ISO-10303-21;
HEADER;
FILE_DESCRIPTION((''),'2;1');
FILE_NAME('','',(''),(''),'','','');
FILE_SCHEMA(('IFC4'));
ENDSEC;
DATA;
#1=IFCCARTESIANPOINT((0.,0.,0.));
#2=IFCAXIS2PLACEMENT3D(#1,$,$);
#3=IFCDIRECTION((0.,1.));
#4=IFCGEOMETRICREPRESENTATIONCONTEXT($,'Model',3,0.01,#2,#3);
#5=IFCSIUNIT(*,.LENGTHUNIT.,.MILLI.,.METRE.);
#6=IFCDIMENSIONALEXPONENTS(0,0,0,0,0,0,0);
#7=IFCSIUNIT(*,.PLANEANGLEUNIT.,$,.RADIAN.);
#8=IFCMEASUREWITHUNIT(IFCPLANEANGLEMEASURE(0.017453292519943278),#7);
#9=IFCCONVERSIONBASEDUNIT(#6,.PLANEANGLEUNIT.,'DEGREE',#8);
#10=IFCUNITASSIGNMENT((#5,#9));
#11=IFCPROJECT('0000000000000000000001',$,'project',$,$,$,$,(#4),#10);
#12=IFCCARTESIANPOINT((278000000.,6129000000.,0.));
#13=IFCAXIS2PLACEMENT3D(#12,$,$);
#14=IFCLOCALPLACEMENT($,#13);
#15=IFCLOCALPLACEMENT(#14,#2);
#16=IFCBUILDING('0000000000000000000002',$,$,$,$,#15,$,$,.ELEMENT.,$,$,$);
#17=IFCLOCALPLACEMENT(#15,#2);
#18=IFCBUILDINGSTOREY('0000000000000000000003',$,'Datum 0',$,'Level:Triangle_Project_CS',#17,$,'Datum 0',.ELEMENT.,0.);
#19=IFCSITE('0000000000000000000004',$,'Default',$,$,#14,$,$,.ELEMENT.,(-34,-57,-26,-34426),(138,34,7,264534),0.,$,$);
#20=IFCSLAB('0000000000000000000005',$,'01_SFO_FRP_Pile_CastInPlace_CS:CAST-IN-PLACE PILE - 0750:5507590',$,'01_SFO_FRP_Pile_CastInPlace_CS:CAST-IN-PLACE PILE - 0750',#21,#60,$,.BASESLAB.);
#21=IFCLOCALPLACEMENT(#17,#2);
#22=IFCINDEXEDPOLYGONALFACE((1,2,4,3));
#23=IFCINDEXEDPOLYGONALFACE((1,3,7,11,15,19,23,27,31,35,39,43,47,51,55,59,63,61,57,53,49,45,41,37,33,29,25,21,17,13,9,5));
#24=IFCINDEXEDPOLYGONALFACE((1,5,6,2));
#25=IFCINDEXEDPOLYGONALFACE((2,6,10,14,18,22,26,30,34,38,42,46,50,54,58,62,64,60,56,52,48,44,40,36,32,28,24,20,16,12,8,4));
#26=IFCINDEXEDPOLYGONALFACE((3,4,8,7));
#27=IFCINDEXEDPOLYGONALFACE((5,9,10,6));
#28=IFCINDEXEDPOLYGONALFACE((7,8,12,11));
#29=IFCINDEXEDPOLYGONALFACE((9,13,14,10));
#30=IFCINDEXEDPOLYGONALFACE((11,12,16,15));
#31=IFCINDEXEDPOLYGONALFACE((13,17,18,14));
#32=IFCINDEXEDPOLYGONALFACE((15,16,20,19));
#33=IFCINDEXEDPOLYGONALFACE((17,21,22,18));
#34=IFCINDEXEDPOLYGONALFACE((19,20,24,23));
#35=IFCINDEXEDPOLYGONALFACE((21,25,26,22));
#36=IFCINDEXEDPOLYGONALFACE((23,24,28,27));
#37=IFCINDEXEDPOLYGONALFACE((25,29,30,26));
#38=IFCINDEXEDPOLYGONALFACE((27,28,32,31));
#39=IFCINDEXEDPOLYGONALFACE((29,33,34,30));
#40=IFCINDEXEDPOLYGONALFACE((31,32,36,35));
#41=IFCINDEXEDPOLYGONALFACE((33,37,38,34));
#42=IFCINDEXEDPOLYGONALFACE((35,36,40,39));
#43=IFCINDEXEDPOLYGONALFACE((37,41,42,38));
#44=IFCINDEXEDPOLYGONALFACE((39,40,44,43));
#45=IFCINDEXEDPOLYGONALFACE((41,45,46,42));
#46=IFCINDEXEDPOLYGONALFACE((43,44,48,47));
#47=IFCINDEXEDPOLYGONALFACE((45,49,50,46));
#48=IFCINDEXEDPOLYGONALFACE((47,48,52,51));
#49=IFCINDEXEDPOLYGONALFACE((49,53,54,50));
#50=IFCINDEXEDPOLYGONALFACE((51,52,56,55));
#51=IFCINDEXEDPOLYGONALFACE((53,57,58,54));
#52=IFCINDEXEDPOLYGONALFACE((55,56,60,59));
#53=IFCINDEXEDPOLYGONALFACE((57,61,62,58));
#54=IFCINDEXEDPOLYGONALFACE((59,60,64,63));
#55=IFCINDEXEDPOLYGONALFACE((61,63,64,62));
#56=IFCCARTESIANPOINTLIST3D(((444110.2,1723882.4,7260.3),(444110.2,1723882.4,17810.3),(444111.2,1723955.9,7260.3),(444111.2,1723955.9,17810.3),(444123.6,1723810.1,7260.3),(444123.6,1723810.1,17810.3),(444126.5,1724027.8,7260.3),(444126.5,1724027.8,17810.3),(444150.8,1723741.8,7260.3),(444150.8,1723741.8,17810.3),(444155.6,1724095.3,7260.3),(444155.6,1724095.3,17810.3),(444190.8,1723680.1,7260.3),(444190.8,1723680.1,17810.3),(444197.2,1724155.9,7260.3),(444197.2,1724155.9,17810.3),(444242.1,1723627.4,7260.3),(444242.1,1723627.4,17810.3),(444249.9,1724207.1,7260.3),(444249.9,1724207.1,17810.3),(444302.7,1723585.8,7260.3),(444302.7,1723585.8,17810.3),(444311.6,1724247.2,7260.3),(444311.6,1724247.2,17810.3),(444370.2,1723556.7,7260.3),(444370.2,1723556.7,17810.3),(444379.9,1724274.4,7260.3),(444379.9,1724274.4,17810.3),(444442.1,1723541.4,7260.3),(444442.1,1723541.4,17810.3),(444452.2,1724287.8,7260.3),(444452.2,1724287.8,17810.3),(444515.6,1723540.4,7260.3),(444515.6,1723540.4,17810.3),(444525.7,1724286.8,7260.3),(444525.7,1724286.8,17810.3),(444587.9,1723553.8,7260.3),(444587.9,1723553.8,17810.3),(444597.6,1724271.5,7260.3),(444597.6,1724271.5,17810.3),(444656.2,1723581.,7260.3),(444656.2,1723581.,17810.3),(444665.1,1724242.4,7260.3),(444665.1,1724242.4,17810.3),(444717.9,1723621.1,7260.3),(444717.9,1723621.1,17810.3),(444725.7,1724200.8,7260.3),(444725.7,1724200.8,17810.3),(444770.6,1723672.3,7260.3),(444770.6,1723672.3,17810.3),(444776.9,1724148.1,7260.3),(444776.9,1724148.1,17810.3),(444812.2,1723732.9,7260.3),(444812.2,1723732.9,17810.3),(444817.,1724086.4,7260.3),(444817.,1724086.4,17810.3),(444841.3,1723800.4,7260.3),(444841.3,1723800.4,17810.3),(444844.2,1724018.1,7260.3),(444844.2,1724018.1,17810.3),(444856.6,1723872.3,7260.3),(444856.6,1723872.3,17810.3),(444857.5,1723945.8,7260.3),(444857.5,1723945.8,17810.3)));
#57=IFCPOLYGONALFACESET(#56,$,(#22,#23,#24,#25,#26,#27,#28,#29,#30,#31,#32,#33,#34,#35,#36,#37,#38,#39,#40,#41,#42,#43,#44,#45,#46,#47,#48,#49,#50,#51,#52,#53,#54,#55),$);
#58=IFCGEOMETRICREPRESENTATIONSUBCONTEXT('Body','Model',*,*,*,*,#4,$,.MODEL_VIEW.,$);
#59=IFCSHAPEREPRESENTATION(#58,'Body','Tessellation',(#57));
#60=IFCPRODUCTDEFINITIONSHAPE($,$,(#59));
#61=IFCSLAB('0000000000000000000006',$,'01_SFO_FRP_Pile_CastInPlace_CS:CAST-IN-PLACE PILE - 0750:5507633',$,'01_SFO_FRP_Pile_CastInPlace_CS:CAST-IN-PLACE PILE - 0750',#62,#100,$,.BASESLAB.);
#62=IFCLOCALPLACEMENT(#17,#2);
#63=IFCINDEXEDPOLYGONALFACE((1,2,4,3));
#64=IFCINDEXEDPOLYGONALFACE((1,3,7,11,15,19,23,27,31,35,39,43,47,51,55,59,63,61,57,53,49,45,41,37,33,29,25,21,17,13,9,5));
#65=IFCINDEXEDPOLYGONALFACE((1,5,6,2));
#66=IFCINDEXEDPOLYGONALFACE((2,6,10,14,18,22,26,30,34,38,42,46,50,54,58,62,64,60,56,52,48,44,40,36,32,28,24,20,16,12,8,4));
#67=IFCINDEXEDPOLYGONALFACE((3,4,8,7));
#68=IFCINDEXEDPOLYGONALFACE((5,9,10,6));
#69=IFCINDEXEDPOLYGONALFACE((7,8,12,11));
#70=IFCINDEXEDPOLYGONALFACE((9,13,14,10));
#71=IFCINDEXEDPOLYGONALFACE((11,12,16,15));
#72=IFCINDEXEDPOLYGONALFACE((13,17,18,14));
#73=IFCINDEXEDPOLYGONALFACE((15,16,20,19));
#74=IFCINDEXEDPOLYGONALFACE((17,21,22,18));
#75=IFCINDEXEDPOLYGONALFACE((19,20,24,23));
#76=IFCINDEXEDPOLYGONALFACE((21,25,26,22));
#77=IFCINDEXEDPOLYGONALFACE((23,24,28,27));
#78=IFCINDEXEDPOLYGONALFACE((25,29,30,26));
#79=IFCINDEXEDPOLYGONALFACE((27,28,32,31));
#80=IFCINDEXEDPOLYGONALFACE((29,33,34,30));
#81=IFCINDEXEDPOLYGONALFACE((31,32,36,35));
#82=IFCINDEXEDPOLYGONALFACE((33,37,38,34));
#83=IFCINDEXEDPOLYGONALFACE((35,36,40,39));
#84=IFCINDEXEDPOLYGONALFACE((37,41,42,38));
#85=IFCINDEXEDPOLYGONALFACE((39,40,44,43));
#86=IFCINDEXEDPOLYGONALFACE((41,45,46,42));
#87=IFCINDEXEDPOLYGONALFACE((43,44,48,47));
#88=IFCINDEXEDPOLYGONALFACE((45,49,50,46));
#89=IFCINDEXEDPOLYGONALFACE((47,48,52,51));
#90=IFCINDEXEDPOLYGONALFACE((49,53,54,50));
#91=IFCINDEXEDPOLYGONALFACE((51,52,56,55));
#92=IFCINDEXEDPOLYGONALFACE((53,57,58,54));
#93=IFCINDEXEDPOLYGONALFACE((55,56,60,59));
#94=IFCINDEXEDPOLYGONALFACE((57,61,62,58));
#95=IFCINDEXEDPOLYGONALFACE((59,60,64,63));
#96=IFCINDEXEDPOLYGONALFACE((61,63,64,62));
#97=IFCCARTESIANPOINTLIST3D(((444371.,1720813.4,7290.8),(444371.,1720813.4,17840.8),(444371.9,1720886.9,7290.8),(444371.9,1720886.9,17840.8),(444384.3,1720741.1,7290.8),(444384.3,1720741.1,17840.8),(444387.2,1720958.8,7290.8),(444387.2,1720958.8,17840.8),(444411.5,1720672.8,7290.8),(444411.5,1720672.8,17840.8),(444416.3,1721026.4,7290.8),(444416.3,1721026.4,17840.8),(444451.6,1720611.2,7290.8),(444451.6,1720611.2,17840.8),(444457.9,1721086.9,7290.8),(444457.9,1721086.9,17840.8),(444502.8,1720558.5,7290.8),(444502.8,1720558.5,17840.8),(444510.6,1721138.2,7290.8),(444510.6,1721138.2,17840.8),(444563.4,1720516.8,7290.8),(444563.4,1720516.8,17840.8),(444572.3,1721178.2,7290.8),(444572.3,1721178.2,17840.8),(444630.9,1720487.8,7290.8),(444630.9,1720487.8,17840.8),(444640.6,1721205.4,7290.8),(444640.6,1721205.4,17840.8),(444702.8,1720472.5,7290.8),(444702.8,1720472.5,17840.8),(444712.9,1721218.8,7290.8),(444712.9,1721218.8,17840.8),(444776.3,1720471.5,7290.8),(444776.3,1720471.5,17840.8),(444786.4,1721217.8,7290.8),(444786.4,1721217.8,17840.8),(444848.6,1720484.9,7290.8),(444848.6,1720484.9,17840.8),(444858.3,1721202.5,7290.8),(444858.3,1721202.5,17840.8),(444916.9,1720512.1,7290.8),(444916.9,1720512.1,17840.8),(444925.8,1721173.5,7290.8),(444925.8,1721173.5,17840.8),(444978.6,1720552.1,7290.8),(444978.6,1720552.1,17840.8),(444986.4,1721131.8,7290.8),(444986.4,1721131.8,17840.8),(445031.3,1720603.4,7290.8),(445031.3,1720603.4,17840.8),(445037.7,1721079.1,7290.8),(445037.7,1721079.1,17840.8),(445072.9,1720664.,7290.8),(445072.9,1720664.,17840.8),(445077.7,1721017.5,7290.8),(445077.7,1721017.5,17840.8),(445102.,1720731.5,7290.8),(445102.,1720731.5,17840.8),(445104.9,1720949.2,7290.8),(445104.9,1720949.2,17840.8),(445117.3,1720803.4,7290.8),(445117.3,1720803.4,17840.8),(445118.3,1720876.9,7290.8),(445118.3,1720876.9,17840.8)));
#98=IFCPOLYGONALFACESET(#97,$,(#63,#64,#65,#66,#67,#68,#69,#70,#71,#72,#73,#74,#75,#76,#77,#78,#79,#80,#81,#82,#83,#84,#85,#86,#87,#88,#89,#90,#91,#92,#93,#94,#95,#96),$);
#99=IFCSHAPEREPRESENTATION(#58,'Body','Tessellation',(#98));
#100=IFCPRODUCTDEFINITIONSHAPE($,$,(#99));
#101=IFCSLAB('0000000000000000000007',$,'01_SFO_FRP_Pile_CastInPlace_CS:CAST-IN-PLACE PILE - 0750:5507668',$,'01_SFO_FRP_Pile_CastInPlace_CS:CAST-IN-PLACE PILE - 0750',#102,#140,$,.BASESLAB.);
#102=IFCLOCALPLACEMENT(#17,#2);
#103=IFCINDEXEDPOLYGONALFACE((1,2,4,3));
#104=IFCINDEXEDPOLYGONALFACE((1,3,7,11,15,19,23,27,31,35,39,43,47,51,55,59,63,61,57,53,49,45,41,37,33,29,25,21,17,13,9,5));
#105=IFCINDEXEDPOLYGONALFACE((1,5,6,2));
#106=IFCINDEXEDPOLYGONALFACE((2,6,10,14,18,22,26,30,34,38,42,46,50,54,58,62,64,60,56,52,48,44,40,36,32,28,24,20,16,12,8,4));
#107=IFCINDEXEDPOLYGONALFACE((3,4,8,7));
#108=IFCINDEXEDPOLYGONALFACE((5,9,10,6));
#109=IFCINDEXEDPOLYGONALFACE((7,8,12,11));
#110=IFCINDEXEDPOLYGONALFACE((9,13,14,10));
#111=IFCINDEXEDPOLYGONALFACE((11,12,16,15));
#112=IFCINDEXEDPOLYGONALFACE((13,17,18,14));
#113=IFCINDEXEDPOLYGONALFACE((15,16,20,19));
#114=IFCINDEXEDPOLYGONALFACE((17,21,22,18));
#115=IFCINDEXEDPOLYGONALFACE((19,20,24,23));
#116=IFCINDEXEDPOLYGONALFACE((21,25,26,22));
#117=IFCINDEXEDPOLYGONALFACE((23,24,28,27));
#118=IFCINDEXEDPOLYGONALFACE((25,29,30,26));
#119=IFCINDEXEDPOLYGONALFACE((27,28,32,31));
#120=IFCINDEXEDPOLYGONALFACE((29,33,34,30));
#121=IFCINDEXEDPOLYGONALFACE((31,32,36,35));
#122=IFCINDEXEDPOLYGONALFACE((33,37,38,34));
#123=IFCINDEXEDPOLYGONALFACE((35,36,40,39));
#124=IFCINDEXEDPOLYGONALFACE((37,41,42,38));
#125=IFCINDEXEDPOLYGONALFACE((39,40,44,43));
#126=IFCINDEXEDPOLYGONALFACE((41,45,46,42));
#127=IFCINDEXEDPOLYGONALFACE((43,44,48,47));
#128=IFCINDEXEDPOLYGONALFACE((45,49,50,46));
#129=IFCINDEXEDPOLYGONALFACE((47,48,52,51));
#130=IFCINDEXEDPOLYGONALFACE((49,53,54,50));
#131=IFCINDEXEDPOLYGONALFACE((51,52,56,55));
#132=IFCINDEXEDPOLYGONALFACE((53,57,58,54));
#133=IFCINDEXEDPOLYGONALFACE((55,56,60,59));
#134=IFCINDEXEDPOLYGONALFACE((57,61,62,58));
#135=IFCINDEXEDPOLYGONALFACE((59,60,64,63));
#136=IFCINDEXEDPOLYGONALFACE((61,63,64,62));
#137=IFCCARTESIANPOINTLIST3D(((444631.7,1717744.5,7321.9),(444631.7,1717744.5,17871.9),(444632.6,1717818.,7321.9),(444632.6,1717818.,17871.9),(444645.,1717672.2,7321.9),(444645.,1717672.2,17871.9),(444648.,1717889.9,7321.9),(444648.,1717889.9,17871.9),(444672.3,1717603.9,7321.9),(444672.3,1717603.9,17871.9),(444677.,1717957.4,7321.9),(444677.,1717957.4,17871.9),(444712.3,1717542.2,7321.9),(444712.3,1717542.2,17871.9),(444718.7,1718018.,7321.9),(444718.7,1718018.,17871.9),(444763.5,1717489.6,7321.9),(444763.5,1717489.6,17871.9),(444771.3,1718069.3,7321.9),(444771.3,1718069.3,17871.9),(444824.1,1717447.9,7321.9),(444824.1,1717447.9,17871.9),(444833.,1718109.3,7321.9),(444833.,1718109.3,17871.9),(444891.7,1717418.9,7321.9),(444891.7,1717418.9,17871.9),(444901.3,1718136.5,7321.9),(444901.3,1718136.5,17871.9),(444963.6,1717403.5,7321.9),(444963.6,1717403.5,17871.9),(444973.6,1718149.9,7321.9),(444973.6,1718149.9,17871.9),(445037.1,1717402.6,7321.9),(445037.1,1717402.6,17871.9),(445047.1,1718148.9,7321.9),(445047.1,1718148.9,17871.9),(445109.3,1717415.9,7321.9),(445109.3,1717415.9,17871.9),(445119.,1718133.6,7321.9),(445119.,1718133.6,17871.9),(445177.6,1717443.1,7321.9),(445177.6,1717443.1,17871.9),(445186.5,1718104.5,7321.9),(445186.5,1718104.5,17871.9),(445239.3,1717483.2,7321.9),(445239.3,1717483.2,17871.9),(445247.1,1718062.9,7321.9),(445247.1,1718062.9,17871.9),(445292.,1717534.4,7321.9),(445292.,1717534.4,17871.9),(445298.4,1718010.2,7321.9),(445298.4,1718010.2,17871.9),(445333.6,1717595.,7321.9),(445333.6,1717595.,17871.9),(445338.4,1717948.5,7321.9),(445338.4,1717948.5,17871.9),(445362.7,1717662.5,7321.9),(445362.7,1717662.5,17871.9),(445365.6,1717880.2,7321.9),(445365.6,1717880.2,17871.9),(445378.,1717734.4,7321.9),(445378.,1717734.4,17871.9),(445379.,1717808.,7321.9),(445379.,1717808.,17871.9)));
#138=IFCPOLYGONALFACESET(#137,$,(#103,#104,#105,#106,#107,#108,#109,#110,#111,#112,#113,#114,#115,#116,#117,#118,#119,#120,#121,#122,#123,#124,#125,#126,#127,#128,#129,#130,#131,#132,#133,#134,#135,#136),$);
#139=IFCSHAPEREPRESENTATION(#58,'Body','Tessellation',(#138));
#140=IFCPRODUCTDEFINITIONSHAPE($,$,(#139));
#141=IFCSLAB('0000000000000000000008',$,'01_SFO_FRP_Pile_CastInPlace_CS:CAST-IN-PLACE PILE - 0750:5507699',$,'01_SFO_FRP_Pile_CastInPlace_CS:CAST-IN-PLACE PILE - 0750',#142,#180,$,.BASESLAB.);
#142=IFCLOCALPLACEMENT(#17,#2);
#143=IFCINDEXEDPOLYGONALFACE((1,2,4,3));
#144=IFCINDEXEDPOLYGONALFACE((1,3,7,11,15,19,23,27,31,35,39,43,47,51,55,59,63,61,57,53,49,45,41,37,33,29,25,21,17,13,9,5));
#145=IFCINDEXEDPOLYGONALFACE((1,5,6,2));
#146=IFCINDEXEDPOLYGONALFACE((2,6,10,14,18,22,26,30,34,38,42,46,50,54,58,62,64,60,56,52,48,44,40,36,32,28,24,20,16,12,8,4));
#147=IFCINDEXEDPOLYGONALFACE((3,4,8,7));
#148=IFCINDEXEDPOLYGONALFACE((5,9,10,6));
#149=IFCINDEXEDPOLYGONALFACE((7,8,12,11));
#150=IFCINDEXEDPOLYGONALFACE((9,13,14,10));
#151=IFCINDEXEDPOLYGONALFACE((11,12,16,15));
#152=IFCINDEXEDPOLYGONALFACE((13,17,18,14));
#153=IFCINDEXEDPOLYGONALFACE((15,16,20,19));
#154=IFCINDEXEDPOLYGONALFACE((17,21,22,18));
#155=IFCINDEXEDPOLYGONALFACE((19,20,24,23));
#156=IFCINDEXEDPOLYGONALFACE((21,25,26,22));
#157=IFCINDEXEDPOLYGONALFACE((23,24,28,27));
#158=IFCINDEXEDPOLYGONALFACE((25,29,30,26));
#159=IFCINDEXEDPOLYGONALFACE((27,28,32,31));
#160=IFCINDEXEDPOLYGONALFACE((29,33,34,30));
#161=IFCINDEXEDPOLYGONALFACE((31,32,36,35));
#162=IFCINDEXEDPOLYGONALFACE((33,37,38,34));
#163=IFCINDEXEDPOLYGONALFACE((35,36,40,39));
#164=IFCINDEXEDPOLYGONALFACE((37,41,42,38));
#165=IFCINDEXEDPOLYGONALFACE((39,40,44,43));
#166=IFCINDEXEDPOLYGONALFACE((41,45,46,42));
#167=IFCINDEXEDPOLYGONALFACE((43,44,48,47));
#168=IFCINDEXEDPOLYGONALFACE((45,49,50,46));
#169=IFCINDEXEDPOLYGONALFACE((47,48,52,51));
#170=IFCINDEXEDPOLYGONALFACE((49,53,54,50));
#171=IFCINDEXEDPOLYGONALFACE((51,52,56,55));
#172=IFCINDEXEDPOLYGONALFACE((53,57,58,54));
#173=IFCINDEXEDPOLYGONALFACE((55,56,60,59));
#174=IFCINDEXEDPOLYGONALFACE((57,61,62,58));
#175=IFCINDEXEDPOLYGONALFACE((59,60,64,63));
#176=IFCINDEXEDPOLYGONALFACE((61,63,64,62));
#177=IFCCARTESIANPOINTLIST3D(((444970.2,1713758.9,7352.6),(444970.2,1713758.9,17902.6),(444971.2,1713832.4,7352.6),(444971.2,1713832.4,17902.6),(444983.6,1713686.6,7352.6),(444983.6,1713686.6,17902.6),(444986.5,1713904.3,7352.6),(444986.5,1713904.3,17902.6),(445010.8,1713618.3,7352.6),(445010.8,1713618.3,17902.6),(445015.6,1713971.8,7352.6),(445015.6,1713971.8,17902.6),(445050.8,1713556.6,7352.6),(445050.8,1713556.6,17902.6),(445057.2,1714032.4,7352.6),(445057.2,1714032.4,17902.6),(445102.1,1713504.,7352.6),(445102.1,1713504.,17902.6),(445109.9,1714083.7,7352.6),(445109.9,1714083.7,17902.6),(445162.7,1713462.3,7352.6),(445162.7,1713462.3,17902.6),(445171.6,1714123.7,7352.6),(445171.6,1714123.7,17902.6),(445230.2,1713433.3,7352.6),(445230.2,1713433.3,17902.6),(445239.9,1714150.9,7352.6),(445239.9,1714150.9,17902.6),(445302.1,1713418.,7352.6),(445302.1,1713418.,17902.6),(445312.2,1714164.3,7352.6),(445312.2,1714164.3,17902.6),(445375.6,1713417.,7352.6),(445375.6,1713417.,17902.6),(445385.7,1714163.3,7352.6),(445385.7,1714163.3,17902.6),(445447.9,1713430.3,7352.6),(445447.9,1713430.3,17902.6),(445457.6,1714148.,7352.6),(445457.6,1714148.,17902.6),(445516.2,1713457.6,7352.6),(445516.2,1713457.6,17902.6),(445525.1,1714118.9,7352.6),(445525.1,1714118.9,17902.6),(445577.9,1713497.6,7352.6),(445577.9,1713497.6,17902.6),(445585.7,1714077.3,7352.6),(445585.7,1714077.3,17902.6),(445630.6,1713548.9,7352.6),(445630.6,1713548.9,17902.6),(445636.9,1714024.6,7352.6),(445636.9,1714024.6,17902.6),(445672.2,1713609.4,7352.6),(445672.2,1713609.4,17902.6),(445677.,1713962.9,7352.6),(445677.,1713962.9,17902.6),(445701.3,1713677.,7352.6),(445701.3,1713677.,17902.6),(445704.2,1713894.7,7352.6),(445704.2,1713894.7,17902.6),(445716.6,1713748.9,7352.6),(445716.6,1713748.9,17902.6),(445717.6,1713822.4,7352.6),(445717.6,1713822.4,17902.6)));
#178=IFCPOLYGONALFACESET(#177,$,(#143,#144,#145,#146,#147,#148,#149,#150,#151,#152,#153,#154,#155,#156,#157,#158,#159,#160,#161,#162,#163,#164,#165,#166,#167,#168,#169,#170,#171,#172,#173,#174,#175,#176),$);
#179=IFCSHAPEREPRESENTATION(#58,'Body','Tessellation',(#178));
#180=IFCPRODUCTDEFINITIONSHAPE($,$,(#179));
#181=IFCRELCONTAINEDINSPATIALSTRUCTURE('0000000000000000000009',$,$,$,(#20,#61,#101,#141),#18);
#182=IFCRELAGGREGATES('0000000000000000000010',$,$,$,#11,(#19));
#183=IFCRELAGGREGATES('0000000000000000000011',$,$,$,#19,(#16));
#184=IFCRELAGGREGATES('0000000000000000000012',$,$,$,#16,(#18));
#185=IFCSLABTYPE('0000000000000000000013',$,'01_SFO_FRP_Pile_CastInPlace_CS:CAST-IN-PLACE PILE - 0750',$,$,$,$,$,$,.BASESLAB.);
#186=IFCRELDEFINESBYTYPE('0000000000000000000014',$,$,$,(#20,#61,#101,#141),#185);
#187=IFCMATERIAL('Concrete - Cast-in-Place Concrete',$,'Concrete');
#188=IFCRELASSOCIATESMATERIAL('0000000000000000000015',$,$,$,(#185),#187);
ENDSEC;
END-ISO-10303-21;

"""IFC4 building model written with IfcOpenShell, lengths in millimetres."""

from ifc_helpers import new_model, entity, si_unit, converted_unit, direction, frame, origin, place, context, subcontext, project, spatial, arc, indexed_curve, outline, extrude, material, type_object, element, save


model = new_model("IFC4")

# Units and contexts
model_context = context("Model", 3, precision=0.01, world=origin(), true_north=direction((0.0, 1.0)))
body_context = subcontext(model_context, "Body", "Model", "MODEL_VIEW")
ifc_project = project(units=[si_unit("LENGTHUNIT", "METRE", prefix="MILLI"), converted_unit("PLANEANGLEUNIT", "DEGREE", entity("IfcPlaneAngleMeasure", 0.017453292519943278), si_unit("PLANEANGLEUNIT", "RADIAN"), dimensions=[0, 0, 0, 0, 0, 0, 0])], contexts=[model_context])

# Site, building, storey
site_placement = place(None, frame((278000000.0, 6129000000.0, 0.0)))
site = spatial("IfcSite", under=ifc_project, at=site_placement, Name="Default", CompositionType="ELEMENT", RefLatitude=(-34, -57, -26, -34426), RefLongitude=(138, 34, 7, 264534), RefElevation=0.0)
building_placement = place(site_placement, origin())
building = spatial("IfcBuilding", under=site, at=building_placement, CompositionType="ELEMENT")
storey_placement = place(building_placement, frame((0.0, 0.0, 0.0)))
storey = spatial("IfcBuildingStorey", under=building, at=storey_placement, Name="Datum 0", ObjectType="Level:Triangle_Project_CS", LongName="Datum 0", CompositionType="ELEMENT", Elevation=0.0)

# Shared definitions
ifc_material_1 = material(Name="Concrete - Cast-in-Place Concrete", Category="Concrete")

# Slabs
slab_type_1 = type_object("IfcSlabType", Name="01_SFO_FRP_Pile_CastInPlace_CS:CAST-IN-PLACE PILE - 0750", PredefinedType="BASESLAB", material=ifc_material_1)
slab_1_placement = place(storey_placement, origin())
element("IfcSlab", 1, at=slab_1_placement, inside=storey, type_object=slab_type_1, Name="01_SFO_FRP_Pile_CastInPlace_CS:CAST-IN-PLACE PILE - 0750:5507590", ObjectType="01_SFO_FRP_Pile_CastInPlace_CS:CAST-IN-PLACE PILE - 0750", PredefinedType="BASESLAB", context=body_context, shape_type="SweptSolid", body=[
    extrude(outline(indexed_curve([(-375.0, 0.0), (0.0, -375.0), (375.0, 0.0), (0.0, 375.0)], segments=[arc(1, 2, 3), arc(3, 4, 1)], self_intersect=False)), frame((444483.9, 1723914.1, 7260.3), z_axis=(0.0, 0.0, 1.0), x_axis=(0.996411, 0.084646, 0.0)), (0.0, 0.0, 1.0), 10550.0),
])
slab_2_placement = place(storey_placement, origin())
element("IfcSlab", 2, at=slab_2_placement, inside=storey, type_object=slab_type_1, Name="01_SFO_FRP_Pile_CastInPlace_CS:CAST-IN-PLACE PILE - 0750:5507633", ObjectType="01_SFO_FRP_Pile_CastInPlace_CS:CAST-IN-PLACE PILE - 0750", PredefinedType="BASESLAB", context=body_context, shape_type="SweptSolid", body=[
    extrude(outline(indexed_curve([(-375.0, 0.0), (0.0, -375.0), (375.0, 0.0), (0.0, 375.0)], segments=[arc(1, 2, 3), arc(3, 4, 1)], self_intersect=False)), frame((444744.6, 1720845.2, 7290.8), z_axis=(0.0, 0.0, 1.0), x_axis=(0.996411, 0.084646, 0.0)), (0.0, 0.0, 1.0), 10550.0),
])
slab_3_placement = place(storey_placement, origin())
element("IfcSlab", 3, at=slab_3_placement, inside=storey, type_object=slab_type_1, Name="01_SFO_FRP_Pile_CastInPlace_CS:CAST-IN-PLACE PILE - 0750:5507668", ObjectType="01_SFO_FRP_Pile_CastInPlace_CS:CAST-IN-PLACE PILE - 0750", PredefinedType="BASESLAB", context=body_context, shape_type="SweptSolid", body=[
    extrude(outline(indexed_curve([(-375.0, 0.0), (0.0, -375.0), (375.0, 0.0), (0.0, 375.0)], segments=[arc(1, 2, 3), arc(3, 4, 1)], self_intersect=False)), frame((445005.3, 1717776.2, 7321.9), z_axis=(0.0, 0.0, 1.0), x_axis=(0.996411, 0.084646, 0.0)), (0.0, 0.0, 1.0), 10550.0),
])
slab_4_placement = place(storey_placement, origin())
element("IfcSlab", 4, at=slab_4_placement, inside=storey, type_object=slab_type_1, Name="01_SFO_FRP_Pile_CastInPlace_CS:CAST-IN-PLACE PILE - 0750:5507699", ObjectType="01_SFO_FRP_Pile_CastInPlace_CS:CAST-IN-PLACE PILE - 0750", PredefinedType="BASESLAB", context=body_context, shape_type="SweptSolid", body=[
    extrude(outline(indexed_curve([(-375.0, 0.0), (0.0, -375.0), (375.0, 0.0), (0.0, 375.0)], segments=[arc(1, 2, 3), arc(3, 4, 1)], self_intersect=False)), frame((445343.9, 1713790.6, 7352.6), z_axis=(0.0, 0.0, 1.0), x_axis=(0.996411, 0.084646, 0.0)), (0.0, 0.0, 1.0), 10550.0),
])

save(model, "model.ifc")
